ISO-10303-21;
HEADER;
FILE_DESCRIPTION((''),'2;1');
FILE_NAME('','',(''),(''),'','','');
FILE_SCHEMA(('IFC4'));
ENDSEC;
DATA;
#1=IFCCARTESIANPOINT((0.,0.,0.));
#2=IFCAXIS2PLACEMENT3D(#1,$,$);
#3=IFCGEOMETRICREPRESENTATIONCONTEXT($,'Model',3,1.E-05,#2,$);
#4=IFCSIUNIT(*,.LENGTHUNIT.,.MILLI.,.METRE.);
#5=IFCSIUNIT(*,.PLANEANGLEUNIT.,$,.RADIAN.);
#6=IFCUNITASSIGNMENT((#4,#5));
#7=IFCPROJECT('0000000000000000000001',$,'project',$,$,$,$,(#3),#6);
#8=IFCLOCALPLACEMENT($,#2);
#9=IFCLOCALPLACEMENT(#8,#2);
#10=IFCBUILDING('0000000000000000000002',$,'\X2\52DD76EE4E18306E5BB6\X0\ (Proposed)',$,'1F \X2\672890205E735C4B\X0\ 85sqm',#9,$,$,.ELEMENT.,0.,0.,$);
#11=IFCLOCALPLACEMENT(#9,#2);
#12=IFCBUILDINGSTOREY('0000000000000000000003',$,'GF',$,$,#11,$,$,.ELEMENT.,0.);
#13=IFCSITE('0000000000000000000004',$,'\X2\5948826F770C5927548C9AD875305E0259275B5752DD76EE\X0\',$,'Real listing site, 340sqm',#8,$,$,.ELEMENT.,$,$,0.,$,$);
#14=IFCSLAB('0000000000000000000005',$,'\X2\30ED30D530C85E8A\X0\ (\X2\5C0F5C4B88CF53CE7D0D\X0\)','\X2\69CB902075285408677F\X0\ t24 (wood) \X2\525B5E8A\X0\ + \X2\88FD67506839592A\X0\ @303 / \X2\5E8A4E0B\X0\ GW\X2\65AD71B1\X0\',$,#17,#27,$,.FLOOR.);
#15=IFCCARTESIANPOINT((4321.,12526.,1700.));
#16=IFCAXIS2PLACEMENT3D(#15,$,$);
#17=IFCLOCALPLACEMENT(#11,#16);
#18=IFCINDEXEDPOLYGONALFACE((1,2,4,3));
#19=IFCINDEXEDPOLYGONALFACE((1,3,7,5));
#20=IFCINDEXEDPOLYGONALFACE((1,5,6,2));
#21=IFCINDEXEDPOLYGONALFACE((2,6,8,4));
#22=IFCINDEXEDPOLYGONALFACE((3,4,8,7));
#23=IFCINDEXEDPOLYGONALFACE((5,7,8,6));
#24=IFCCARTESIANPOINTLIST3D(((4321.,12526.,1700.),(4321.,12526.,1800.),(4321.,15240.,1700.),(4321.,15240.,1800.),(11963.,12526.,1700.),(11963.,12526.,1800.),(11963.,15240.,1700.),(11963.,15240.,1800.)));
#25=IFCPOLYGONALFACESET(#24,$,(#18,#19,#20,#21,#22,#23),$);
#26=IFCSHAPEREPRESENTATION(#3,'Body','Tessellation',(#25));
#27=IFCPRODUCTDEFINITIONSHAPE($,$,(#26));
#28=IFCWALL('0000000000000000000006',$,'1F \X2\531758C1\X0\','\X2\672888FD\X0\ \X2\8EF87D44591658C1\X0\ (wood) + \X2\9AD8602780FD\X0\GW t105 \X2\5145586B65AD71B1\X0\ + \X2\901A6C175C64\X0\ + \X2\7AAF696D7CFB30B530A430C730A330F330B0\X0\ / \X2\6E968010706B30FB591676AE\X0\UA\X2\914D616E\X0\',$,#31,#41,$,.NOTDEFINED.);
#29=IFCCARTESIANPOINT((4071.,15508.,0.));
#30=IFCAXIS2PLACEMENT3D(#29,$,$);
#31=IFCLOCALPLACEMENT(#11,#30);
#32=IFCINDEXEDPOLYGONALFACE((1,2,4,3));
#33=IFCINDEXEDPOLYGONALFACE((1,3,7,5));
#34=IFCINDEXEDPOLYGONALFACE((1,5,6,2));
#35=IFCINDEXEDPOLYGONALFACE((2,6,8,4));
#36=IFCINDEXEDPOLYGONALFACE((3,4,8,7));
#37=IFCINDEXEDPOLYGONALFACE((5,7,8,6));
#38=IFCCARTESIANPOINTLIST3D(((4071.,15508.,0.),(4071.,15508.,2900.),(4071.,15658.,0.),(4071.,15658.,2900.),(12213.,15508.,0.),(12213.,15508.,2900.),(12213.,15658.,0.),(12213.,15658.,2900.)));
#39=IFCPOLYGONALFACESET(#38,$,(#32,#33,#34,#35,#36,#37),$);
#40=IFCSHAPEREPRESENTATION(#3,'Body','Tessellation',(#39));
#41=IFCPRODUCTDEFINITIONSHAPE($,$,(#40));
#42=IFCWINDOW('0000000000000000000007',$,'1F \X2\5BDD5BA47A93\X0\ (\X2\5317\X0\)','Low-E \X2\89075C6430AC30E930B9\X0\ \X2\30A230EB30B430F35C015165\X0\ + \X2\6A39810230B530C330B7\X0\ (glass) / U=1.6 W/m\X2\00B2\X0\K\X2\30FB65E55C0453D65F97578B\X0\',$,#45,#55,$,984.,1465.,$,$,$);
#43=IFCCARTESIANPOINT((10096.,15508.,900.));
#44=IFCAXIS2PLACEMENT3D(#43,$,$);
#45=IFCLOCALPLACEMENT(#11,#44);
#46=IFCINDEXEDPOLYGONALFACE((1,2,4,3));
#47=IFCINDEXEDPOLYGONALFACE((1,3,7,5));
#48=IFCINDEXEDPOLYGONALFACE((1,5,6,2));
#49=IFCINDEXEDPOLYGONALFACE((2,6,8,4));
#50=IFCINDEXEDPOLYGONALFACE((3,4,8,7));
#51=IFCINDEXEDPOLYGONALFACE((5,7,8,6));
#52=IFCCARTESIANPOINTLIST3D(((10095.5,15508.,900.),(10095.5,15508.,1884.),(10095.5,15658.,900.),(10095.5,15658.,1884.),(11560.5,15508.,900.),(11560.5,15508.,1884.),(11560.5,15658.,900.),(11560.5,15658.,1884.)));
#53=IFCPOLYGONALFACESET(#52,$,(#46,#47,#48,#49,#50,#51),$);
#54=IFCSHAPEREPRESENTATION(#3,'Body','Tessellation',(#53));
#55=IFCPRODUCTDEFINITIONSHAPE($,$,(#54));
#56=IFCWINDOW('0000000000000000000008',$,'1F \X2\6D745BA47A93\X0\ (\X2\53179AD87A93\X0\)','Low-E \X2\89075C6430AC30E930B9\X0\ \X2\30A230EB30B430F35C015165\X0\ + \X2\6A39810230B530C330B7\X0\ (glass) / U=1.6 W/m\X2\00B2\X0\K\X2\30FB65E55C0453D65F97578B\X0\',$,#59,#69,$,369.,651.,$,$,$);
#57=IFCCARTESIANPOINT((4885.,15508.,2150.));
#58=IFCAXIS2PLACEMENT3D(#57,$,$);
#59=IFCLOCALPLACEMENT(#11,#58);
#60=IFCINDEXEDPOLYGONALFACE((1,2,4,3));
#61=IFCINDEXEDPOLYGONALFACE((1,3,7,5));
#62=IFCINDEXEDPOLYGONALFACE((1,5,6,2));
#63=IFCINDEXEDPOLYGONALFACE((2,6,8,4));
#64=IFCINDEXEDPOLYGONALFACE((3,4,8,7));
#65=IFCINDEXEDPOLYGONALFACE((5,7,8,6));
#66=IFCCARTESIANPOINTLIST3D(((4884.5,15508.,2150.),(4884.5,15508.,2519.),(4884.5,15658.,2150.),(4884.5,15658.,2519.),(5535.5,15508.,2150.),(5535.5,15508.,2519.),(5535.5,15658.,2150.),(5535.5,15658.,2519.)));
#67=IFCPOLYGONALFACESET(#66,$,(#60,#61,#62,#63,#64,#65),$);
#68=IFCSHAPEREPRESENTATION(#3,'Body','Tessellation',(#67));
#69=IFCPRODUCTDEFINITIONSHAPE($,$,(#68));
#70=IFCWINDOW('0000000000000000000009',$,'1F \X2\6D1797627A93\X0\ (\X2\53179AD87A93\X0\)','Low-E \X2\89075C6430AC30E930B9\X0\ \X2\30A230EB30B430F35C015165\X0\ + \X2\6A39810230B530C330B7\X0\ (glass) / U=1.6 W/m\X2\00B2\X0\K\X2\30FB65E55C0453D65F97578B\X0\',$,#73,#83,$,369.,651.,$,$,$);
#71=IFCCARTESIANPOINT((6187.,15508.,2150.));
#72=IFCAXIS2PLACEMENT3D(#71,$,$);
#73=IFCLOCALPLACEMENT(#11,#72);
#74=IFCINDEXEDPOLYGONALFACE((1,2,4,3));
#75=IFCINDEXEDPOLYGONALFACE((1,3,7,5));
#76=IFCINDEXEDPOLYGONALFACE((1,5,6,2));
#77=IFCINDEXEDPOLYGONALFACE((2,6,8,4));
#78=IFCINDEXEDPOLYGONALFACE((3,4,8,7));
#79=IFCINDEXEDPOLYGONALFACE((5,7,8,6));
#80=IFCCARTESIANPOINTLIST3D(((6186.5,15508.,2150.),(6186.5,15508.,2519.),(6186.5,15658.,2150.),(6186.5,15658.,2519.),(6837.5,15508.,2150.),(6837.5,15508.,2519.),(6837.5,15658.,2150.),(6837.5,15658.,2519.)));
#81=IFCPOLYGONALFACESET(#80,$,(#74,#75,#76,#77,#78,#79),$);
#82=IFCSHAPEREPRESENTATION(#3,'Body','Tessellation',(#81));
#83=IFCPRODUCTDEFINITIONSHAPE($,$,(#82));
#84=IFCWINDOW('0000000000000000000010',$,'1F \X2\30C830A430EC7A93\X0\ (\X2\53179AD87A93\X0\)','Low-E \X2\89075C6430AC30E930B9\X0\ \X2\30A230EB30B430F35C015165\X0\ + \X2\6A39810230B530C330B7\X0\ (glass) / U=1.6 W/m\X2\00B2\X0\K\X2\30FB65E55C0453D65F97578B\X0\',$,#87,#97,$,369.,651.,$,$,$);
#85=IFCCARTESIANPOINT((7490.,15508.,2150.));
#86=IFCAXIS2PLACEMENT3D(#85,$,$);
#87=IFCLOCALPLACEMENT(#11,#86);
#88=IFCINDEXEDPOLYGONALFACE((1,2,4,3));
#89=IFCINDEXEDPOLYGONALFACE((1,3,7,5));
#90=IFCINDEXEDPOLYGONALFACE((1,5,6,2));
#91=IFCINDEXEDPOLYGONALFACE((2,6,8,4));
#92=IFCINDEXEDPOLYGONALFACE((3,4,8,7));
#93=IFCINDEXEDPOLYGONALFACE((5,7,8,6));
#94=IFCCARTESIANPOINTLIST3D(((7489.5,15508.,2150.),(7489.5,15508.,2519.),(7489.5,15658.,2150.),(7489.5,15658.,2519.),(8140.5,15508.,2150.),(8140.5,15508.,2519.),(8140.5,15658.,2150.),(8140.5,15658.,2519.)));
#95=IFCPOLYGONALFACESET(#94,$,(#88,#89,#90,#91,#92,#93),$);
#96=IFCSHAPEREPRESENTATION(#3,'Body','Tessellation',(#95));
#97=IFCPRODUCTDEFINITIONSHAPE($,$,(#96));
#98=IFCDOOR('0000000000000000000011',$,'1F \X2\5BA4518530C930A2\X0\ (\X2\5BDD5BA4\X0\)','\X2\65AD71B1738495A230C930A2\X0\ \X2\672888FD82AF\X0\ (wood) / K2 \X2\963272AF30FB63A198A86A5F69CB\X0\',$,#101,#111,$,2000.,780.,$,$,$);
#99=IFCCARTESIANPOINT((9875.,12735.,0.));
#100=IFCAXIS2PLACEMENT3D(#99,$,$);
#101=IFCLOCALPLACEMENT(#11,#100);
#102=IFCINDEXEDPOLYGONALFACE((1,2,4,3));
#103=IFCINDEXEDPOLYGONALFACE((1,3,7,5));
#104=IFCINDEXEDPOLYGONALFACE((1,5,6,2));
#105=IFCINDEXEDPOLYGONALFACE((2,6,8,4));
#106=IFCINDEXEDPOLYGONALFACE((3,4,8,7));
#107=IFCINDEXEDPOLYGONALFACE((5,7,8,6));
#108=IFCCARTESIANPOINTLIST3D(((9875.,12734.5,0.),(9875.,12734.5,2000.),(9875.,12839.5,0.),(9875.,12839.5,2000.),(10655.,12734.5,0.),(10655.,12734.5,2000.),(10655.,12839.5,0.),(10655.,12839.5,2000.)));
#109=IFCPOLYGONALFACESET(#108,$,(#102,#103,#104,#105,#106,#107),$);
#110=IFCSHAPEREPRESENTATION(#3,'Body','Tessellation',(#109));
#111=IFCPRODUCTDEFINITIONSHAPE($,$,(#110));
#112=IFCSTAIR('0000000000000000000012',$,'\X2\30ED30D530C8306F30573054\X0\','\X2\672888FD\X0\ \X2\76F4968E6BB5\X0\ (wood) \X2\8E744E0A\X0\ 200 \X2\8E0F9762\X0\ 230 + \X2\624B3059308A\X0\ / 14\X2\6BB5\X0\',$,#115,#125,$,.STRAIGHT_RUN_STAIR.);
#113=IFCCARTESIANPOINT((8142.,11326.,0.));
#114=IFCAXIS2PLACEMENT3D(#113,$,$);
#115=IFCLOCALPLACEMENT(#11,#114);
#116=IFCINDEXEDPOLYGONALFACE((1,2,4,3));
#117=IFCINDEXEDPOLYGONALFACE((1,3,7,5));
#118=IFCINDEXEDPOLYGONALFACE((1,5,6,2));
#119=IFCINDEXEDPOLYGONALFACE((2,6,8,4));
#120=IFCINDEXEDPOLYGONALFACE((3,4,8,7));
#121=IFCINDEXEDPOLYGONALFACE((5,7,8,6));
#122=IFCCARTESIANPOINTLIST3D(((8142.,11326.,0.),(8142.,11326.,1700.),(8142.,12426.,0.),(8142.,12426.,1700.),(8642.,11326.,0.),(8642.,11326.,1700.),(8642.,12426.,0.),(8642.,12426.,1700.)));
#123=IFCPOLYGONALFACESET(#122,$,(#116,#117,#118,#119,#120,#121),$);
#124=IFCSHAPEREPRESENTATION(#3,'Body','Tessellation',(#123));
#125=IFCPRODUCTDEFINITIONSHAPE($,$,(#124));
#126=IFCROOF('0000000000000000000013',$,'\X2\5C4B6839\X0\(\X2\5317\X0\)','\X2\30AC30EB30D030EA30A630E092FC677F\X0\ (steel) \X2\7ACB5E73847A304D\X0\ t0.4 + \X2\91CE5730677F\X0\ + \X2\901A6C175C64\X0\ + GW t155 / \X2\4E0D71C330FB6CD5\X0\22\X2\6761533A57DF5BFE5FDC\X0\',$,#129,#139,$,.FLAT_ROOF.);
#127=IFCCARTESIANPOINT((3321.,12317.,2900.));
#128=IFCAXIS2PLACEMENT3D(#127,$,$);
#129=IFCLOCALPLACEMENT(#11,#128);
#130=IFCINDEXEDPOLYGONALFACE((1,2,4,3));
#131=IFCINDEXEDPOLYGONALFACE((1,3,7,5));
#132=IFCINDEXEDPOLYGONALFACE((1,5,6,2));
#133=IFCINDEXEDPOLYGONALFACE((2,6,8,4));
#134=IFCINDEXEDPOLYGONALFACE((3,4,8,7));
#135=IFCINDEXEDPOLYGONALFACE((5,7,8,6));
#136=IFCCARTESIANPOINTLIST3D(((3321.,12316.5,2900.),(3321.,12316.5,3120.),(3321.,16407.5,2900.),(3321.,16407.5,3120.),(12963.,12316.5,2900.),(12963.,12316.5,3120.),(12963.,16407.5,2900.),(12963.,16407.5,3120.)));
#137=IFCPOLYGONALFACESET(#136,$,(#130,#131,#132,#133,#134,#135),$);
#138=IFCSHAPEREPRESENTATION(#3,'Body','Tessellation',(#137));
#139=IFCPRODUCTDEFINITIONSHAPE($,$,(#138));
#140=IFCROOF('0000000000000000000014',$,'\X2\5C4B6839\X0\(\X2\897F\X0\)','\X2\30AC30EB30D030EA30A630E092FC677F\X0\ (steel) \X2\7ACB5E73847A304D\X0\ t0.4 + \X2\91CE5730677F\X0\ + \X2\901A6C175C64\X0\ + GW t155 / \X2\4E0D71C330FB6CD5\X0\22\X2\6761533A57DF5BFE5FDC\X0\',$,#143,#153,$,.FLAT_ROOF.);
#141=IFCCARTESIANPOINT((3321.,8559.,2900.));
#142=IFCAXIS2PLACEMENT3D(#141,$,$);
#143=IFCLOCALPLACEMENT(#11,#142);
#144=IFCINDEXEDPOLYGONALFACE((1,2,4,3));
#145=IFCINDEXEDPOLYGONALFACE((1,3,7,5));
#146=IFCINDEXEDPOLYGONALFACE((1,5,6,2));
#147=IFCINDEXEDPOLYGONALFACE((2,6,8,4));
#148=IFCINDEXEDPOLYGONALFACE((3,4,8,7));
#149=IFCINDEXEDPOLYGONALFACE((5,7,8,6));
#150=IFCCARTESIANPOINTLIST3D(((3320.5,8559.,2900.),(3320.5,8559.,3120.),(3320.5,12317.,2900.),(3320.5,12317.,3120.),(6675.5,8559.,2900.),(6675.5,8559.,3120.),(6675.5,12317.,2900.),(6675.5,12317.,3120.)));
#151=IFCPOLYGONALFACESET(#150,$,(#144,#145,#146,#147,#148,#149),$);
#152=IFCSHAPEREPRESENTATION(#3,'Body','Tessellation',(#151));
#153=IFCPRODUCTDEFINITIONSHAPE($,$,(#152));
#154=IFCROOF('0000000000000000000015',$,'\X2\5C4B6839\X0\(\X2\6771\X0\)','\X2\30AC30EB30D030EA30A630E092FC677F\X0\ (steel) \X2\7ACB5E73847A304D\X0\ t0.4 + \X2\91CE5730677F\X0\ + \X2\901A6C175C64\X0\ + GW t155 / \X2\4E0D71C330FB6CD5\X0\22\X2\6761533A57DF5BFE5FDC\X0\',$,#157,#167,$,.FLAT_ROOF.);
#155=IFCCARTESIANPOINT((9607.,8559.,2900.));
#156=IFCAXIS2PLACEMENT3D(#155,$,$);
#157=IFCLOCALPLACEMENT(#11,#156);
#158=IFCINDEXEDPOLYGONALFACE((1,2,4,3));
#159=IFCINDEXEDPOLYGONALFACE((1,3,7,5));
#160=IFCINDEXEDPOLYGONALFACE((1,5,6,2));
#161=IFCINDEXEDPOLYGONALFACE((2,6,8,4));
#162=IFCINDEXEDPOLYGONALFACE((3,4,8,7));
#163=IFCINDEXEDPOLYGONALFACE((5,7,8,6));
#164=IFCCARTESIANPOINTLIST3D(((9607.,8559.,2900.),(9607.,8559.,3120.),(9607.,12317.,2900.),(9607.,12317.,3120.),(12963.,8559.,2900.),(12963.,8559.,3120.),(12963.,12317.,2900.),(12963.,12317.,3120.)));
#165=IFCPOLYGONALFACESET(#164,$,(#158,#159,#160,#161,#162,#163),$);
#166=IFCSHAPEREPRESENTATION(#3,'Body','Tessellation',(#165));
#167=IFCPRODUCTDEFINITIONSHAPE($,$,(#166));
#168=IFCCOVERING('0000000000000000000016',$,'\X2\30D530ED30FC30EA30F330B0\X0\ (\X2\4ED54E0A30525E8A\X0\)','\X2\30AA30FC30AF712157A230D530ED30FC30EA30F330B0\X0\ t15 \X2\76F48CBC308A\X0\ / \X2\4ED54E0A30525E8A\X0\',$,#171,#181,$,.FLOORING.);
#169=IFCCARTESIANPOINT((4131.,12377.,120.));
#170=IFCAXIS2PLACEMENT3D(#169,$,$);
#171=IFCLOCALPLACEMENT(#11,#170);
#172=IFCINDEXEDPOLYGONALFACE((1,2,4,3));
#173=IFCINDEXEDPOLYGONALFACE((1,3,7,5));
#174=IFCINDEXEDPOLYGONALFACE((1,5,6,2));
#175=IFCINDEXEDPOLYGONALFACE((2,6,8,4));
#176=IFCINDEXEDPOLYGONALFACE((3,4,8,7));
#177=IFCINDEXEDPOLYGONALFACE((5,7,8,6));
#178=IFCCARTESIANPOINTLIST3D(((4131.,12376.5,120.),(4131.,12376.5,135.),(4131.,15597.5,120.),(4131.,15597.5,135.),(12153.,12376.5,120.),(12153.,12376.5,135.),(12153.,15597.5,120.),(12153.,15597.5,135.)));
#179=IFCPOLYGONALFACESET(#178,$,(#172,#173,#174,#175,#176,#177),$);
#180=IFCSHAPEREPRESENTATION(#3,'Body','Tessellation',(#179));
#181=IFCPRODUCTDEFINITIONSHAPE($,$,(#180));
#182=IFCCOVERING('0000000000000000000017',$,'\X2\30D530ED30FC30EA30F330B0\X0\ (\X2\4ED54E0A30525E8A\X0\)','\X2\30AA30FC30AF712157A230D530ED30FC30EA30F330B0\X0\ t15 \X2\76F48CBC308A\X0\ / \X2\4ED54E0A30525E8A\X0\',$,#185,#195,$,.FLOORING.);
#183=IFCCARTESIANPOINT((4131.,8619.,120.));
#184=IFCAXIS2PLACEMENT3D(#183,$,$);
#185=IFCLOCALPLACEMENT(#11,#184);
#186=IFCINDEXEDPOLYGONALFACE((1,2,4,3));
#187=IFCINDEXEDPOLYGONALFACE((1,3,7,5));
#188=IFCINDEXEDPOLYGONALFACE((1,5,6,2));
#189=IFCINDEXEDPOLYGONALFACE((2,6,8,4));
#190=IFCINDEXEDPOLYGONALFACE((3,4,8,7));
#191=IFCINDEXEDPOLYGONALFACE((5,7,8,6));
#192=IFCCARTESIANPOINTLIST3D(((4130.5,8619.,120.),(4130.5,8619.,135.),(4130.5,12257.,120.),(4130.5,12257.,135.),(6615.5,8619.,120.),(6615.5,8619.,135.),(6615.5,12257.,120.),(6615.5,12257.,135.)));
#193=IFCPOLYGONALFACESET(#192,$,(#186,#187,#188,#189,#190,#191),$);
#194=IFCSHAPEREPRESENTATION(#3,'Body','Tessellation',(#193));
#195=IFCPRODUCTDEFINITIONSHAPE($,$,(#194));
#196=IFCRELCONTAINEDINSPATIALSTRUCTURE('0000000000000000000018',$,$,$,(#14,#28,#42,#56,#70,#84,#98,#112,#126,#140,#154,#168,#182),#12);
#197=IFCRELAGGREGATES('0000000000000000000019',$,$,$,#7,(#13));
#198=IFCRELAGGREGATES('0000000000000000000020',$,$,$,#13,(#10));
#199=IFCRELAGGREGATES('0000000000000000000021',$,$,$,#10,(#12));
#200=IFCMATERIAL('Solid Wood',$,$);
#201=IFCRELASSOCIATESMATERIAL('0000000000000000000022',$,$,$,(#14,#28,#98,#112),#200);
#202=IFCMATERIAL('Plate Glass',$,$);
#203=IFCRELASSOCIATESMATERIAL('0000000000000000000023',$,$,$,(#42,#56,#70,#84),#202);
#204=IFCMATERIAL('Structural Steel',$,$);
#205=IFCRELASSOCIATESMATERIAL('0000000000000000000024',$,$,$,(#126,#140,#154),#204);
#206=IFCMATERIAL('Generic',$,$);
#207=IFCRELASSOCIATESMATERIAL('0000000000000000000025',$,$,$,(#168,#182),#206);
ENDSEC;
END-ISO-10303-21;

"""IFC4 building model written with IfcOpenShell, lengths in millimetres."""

from ifc_helpers import new_model, si_unit, frame, frame_2d, origin, place, context, project, spatial, rectangle, extrude, material, element, fill, save


model = new_model("IFC4")

# Units and contexts
model_context = context("Model", 3, precision=1e-05, world=origin())
ifc_project = project(units=[si_unit("LENGTHUNIT", "METRE", prefix="MILLI"), si_unit("PLANEANGLEUNIT", "RADIAN")], contexts=[model_context])

# Site, building, storey
site_placement = place(None, origin())
site = spatial("IfcSite", under=ifc_project, at=site_placement, Name="奈良県大和高田市大字勝目", ObjectType="Real listing site, 340sqm", CompositionType="ELEMENT", RefElevation=0.0)
building_placement = place(site_placement, origin())
building = spatial("IfcBuilding", under=site, at=building_placement, Name="勝目丘の家 (Proposed)", ObjectType="1F 木造平屋 85sqm", CompositionType="ELEMENT", ElevationOfRefHeight=0.0, ElevationOfTerrain=0.0)
storey_placement = place(building_placement, origin())
storey = spatial("IfcBuildingStorey", under=building, at=storey_placement, Name="GF", CompositionType="ELEMENT", Elevation=0.0)

# Slab
ifc_material_1 = material(Name="Solid Wood")
slab_1_placement = place(storey_placement, frame((4321.0, 12526.0, 1700.0)))
element("IfcSlab", 1, at=slab_1_placement, inside=storey, material=ifc_material_1, Name="ロフト床 (小屋裏収納)", Description="構造用合板 t24 (wood) 剛床 + 製材根太 @303 / 床下 GW断熱", PredefinedType="FLOOR", context=model_context, shape_type="SweptSolid", body=[
    extrude(rectangle(XDim=7642.0, YDim=2714.0, at=frame_2d((3821.0, 1357.0))), frame((4321.0, 12526.0, 1700.0)), (0.0, 0.0, 1.0), 100.0),
])

# Wall, openings, windows
wall_1_placement = place(storey_placement, frame((4071.0, 15508.0, 0.0)))
wall_1 = element("IfcWall", 2, at=wall_1_placement, inside=storey, material=ifc_material_1, Name="1F 北壁", Description="木製 軸組外壁 (wood) + 高性能GW t105 充填断熱 + 通気層 + 窯業系サイディング / 準耐火・外皮UA配慮", PredefinedType="NOTDEFINED", context=model_context, shape_type="SweptSolid", body=[
    extrude(rectangle(XDim=8142.0, YDim=150.0, at=frame_2d((4071.0, 75.0))), frame((4071.0, 15508.0, 0.0)), (0.0, 0.0, 1.0), 2900.0),
])
opening_1_placement = place(storey_placement, frame((10096.0, 15508.0, 900.0)))
opening_1 = element("IfcOpeningElement", 3, at=opening_1_placement, cuts=wall_1, PredefinedType="NOTDEFINED", context=model_context, shape_type="SweptSolid", body=[
    extrude(rectangle(XDim=1465.0, YDim=150.0, at=frame_2d((732.0, 75.0))), frame((10096.0, 15508.0, 900.0)), (0.0, 0.0, 1.0), 984.0),
])
opening_2_placement = place(storey_placement, frame((4885.0, 15508.0, 2150.0)))
opening_2 = element("IfcOpeningElement", 4, at=opening_2_placement, cuts=wall_1, PredefinedType="NOTDEFINED", context=model_context, shape_type="SweptSolid", body=[
    extrude(rectangle(XDim=651.0, YDim=150.0, at=frame_2d((325.0, 75.0))), frame((4885.0, 15508.0, 2150.0)), (0.0, 0.0, 1.0), 369.0),
])
opening_3_placement = place(storey_placement, frame((6187.0, 15508.0, 2150.0)))
opening_3 = element("IfcOpeningElement", 5, at=opening_3_placement, cuts=wall_1, PredefinedType="NOTDEFINED", context=model_context, shape_type="SweptSolid", body=[
    extrude(rectangle(XDim=651.0, YDim=150.0, at=frame_2d((325.0, 75.0))), frame((6187.0, 15508.0, 2150.0)), (0.0, 0.0, 1.0), 369.0),
])
opening_4_placement = place(storey_placement, frame((7490.0, 15508.0, 2150.0)))
opening_4 = element("IfcOpeningElement", 6, at=opening_4_placement, cuts=wall_1, PredefinedType="NOTDEFINED", context=model_context, shape_type="SweptSolid", body=[
    extrude(rectangle(XDim=651.0, YDim=150.0, at=frame_2d((325.0, 75.0))), frame((7490.0, 15508.0, 2150.0)), (0.0, 0.0, 1.0), 369.0),
])
ifc_material_2 = material(Name="Plate Glass")
window_1_placement = place(storey_placement, frame((10096.0, 15508.0, 900.0)))
window_1 = element("IfcWindow", 7, at=window_1_placement, inside=storey, material=ifc_material_2, Name="1F 寝室窓 (北)", Description="Low-E 複層ガラス アルゴン封入 + 樹脂サッシ (glass) / U=1.6 W/m²K・日射取得型", OverallHeight=984.0, OverallWidth=1465.0, context=model_context, shape_type="SweptSolid", body=[
    extrude(rectangle(XDim=1465.0, YDim=150.0, at=frame_2d((732.0, 75.0))), frame((10096.0, 15508.0, 900.0)), (0.0, 0.0, 1.0), 984.0),
])
fill(opening_1, window_1)
window_2_placement = place(storey_placement, frame((4885.0, 15508.0, 2150.0)))
window_2 = element("IfcWindow", 8, at=window_2_placement, inside=storey, material=ifc_material_2, Name="1F 浴室窓 (北高窓)", Description="Low-E 複層ガラス アルゴン封入 + 樹脂サッシ (glass) / U=1.6 W/m²K・日射取得型", OverallHeight=369.0, OverallWidth=651.0, context=model_context, shape_type="SweptSolid", body=[
    extrude(rectangle(XDim=651.0, YDim=150.0, at=frame_2d((325.0, 75.0))), frame((4885.0, 15508.0, 2150.0)), (0.0, 0.0, 1.0), 369.0),
])
fill(opening_2, window_2)
window_3_placement = place(storey_placement, frame((6187.0, 15508.0, 2150.0)))
window_3 = element("IfcWindow", 9, at=window_3_placement, inside=storey, material=ifc_material_2, Name="1F 洗面窓 (北高窓)", Description="Low-E 複層ガラス アルゴン封入 + 樹脂サッシ (glass) / U=1.6 W/m²K・日射取得型", OverallHeight=369.0, OverallWidth=651.0, context=model_context, shape_type="SweptSolid", body=[
    extrude(rectangle(XDim=651.0, YDim=150.0, at=frame_2d((325.0, 75.0))), frame((6187.0, 15508.0, 2150.0)), (0.0, 0.0, 1.0), 369.0),
])
fill(opening_3, window_3)
window_4_placement = place(storey_placement, frame((7490.0, 15508.0, 2150.0)))
window_4 = element("IfcWindow", 10, at=window_4_placement, inside=storey, material=ifc_material_2, Name="1F トイレ窓 (北高窓)", Description="Low-E 複層ガラス アルゴン封入 + 樹脂サッシ (glass) / U=1.6 W/m²K・日射取得型", OverallHeight=369.0, OverallWidth=651.0, context=model_context, shape_type="SweptSolid", body=[
    extrude(rectangle(XDim=651.0, YDim=150.0, at=frame_2d((325.0, 75.0))), frame((7490.0, 15508.0, 2150.0)), (0.0, 0.0, 1.0), 369.0),
])
fill(opening_4, window_4)

# Door
door_1_placement = place(storey_placement, frame((9875.0, 12735.0, 0.0)))
element("IfcDoor", 11, at=door_1_placement, inside=storey, material=ifc_material_1, Name="1F 室内ドア (寝室)", Description="断熱玄関ドア 木製芯 (wood) / K2 防犯・採風機構", OverallHeight=2000.0, OverallWidth=780.0, context=model_context, shape_type="SweptSolid", body=[
    extrude(rectangle(XDim=780.0, YDim=105.0, at=frame_2d((390.0, 52.0))), frame((9875.0, 12735.0, 0.0)), (0.0, 0.0, 1.0), 2000.0),
])

# Stair
stair_placement = place(storey_placement, frame((8142.0, 11326.0, 0.0)))
element("IfcStair", 12, at=stair_placement, inside=storey, material=ifc_material_1, Name="ロフトはしご", Description="木製 直階段 (wood) 蹴上 200 踏面 230 + 手すり / 14段", PredefinedType="STRAIGHT_RUN_STAIR", context=model_context, shape_type="SweptSolid", body=[
    extrude(rectangle(XDim=500.0, YDim=1100.0, at=frame_2d((250.0, 550.0))), frame((8142.0, 11326.0, 0.0)), (0.0, 0.0, 1.0), 1700.0),
])

# Roofs
ifc_material_3 = material(Name="Structural Steel")
roof_1_placement = place(storey_placement, frame((3321.0, 12317.0, 2900.0)))
element("IfcRoof", 13, at=roof_1_placement, inside=storey, material=ifc_material_3, Name="屋根(北)", Description="ガルバリウム鋼板 (steel) 立平葺き t0.4 + 野地板 + 通気層 + GW t155 / 不燃・法22条区域対応", PredefinedType="FLAT_ROOF", context=model_context, shape_type="SweptSolid", body=[
    extrude(rectangle(XDim=9642.0, YDim=4091.0, at=frame_2d((4821.0, 2045.0))), frame((3321.0, 12317.0, 2900.0)), (0.0, 0.0, 1.0), 220.0),
])
roof_2_placement = place(storey_placement, frame((3321.0, 8559.0, 2900.0)))
element("IfcRoof", 14, at=roof_2_placement, inside=storey, material=ifc_material_3, Name="屋根(西)", Description="ガルバリウム鋼板 (steel) 立平葺き t0.4 + 野地板 + 通気層 + GW t155 / 不燃・法22条区域対応", PredefinedType="FLAT_ROOF", context=model_context, shape_type="SweptSolid", body=[
    extrude(rectangle(XDim=3355.0, YDim=3758.0, at=frame_2d((1677.0, 1879.0))), frame((3321.0, 8559.0, 2900.0)), (0.0, 0.0, 1.0), 220.0),
])
roof_3_placement = place(storey_placement, frame((9607.0, 8559.0, 2900.0)))
element("IfcRoof", 15, at=roof_3_placement, inside=storey, material=ifc_material_3, Name="屋根(東)", Description="ガルバリウム鋼板 (steel) 立平葺き t0.4 + 野地板 + 通気層 + GW t155 / 不燃・法22条区域対応", PredefinedType="FLAT_ROOF", context=model_context, shape_type="SweptSolid", body=[
    extrude(rectangle(XDim=3356.0, YDim=3758.0, at=frame_2d((1678.0, 1879.0))), frame((9607.0, 8559.0, 2900.0)), (0.0, 0.0, 1.0), 220.0),
])

# Coverings
ifc_material_4 = material(Name="Generic")
covering_1_placement = place(storey_placement, frame((4131.0, 12377.0, 120.0)))
element("IfcCovering", 16, at=covering_1_placement, inside=storey, material=ifc_material_4, Name="フローリング (仕上げ床)", Description="オーク無垢フローリング t15 直貼り / 仕上げ床", PredefinedType="FLOORING", context=model_context, shape_type="SweptSolid", body=[
    extrude(rectangle(XDim=8022.0, YDim=3221.0, at=frame_2d((4011.0, 1610.0))), frame((4131.0, 12377.0, 120.0)), (0.0, 0.0, 1.0), 15.0),
])
covering_2_placement = place(storey_placement, frame((4131.0, 8619.0, 120.0)))
element("IfcCovering", 17, at=covering_2_placement, inside=storey, material=ifc_material_4, Name="フローリング (仕上げ床)", Description="オーク無垢フローリング t15 直貼り / 仕上げ床", PredefinedType="FLOORING", context=model_context, shape_type="SweptSolid", body=[
    extrude(rectangle(XDim=2485.0, YDim=3638.0, at=frame_2d((1242.0, 1819.0))), frame((4131.0, 8619.0, 120.0)), (0.0, 0.0, 1.0), 15.0),
])

save(model, "model.ifc")
